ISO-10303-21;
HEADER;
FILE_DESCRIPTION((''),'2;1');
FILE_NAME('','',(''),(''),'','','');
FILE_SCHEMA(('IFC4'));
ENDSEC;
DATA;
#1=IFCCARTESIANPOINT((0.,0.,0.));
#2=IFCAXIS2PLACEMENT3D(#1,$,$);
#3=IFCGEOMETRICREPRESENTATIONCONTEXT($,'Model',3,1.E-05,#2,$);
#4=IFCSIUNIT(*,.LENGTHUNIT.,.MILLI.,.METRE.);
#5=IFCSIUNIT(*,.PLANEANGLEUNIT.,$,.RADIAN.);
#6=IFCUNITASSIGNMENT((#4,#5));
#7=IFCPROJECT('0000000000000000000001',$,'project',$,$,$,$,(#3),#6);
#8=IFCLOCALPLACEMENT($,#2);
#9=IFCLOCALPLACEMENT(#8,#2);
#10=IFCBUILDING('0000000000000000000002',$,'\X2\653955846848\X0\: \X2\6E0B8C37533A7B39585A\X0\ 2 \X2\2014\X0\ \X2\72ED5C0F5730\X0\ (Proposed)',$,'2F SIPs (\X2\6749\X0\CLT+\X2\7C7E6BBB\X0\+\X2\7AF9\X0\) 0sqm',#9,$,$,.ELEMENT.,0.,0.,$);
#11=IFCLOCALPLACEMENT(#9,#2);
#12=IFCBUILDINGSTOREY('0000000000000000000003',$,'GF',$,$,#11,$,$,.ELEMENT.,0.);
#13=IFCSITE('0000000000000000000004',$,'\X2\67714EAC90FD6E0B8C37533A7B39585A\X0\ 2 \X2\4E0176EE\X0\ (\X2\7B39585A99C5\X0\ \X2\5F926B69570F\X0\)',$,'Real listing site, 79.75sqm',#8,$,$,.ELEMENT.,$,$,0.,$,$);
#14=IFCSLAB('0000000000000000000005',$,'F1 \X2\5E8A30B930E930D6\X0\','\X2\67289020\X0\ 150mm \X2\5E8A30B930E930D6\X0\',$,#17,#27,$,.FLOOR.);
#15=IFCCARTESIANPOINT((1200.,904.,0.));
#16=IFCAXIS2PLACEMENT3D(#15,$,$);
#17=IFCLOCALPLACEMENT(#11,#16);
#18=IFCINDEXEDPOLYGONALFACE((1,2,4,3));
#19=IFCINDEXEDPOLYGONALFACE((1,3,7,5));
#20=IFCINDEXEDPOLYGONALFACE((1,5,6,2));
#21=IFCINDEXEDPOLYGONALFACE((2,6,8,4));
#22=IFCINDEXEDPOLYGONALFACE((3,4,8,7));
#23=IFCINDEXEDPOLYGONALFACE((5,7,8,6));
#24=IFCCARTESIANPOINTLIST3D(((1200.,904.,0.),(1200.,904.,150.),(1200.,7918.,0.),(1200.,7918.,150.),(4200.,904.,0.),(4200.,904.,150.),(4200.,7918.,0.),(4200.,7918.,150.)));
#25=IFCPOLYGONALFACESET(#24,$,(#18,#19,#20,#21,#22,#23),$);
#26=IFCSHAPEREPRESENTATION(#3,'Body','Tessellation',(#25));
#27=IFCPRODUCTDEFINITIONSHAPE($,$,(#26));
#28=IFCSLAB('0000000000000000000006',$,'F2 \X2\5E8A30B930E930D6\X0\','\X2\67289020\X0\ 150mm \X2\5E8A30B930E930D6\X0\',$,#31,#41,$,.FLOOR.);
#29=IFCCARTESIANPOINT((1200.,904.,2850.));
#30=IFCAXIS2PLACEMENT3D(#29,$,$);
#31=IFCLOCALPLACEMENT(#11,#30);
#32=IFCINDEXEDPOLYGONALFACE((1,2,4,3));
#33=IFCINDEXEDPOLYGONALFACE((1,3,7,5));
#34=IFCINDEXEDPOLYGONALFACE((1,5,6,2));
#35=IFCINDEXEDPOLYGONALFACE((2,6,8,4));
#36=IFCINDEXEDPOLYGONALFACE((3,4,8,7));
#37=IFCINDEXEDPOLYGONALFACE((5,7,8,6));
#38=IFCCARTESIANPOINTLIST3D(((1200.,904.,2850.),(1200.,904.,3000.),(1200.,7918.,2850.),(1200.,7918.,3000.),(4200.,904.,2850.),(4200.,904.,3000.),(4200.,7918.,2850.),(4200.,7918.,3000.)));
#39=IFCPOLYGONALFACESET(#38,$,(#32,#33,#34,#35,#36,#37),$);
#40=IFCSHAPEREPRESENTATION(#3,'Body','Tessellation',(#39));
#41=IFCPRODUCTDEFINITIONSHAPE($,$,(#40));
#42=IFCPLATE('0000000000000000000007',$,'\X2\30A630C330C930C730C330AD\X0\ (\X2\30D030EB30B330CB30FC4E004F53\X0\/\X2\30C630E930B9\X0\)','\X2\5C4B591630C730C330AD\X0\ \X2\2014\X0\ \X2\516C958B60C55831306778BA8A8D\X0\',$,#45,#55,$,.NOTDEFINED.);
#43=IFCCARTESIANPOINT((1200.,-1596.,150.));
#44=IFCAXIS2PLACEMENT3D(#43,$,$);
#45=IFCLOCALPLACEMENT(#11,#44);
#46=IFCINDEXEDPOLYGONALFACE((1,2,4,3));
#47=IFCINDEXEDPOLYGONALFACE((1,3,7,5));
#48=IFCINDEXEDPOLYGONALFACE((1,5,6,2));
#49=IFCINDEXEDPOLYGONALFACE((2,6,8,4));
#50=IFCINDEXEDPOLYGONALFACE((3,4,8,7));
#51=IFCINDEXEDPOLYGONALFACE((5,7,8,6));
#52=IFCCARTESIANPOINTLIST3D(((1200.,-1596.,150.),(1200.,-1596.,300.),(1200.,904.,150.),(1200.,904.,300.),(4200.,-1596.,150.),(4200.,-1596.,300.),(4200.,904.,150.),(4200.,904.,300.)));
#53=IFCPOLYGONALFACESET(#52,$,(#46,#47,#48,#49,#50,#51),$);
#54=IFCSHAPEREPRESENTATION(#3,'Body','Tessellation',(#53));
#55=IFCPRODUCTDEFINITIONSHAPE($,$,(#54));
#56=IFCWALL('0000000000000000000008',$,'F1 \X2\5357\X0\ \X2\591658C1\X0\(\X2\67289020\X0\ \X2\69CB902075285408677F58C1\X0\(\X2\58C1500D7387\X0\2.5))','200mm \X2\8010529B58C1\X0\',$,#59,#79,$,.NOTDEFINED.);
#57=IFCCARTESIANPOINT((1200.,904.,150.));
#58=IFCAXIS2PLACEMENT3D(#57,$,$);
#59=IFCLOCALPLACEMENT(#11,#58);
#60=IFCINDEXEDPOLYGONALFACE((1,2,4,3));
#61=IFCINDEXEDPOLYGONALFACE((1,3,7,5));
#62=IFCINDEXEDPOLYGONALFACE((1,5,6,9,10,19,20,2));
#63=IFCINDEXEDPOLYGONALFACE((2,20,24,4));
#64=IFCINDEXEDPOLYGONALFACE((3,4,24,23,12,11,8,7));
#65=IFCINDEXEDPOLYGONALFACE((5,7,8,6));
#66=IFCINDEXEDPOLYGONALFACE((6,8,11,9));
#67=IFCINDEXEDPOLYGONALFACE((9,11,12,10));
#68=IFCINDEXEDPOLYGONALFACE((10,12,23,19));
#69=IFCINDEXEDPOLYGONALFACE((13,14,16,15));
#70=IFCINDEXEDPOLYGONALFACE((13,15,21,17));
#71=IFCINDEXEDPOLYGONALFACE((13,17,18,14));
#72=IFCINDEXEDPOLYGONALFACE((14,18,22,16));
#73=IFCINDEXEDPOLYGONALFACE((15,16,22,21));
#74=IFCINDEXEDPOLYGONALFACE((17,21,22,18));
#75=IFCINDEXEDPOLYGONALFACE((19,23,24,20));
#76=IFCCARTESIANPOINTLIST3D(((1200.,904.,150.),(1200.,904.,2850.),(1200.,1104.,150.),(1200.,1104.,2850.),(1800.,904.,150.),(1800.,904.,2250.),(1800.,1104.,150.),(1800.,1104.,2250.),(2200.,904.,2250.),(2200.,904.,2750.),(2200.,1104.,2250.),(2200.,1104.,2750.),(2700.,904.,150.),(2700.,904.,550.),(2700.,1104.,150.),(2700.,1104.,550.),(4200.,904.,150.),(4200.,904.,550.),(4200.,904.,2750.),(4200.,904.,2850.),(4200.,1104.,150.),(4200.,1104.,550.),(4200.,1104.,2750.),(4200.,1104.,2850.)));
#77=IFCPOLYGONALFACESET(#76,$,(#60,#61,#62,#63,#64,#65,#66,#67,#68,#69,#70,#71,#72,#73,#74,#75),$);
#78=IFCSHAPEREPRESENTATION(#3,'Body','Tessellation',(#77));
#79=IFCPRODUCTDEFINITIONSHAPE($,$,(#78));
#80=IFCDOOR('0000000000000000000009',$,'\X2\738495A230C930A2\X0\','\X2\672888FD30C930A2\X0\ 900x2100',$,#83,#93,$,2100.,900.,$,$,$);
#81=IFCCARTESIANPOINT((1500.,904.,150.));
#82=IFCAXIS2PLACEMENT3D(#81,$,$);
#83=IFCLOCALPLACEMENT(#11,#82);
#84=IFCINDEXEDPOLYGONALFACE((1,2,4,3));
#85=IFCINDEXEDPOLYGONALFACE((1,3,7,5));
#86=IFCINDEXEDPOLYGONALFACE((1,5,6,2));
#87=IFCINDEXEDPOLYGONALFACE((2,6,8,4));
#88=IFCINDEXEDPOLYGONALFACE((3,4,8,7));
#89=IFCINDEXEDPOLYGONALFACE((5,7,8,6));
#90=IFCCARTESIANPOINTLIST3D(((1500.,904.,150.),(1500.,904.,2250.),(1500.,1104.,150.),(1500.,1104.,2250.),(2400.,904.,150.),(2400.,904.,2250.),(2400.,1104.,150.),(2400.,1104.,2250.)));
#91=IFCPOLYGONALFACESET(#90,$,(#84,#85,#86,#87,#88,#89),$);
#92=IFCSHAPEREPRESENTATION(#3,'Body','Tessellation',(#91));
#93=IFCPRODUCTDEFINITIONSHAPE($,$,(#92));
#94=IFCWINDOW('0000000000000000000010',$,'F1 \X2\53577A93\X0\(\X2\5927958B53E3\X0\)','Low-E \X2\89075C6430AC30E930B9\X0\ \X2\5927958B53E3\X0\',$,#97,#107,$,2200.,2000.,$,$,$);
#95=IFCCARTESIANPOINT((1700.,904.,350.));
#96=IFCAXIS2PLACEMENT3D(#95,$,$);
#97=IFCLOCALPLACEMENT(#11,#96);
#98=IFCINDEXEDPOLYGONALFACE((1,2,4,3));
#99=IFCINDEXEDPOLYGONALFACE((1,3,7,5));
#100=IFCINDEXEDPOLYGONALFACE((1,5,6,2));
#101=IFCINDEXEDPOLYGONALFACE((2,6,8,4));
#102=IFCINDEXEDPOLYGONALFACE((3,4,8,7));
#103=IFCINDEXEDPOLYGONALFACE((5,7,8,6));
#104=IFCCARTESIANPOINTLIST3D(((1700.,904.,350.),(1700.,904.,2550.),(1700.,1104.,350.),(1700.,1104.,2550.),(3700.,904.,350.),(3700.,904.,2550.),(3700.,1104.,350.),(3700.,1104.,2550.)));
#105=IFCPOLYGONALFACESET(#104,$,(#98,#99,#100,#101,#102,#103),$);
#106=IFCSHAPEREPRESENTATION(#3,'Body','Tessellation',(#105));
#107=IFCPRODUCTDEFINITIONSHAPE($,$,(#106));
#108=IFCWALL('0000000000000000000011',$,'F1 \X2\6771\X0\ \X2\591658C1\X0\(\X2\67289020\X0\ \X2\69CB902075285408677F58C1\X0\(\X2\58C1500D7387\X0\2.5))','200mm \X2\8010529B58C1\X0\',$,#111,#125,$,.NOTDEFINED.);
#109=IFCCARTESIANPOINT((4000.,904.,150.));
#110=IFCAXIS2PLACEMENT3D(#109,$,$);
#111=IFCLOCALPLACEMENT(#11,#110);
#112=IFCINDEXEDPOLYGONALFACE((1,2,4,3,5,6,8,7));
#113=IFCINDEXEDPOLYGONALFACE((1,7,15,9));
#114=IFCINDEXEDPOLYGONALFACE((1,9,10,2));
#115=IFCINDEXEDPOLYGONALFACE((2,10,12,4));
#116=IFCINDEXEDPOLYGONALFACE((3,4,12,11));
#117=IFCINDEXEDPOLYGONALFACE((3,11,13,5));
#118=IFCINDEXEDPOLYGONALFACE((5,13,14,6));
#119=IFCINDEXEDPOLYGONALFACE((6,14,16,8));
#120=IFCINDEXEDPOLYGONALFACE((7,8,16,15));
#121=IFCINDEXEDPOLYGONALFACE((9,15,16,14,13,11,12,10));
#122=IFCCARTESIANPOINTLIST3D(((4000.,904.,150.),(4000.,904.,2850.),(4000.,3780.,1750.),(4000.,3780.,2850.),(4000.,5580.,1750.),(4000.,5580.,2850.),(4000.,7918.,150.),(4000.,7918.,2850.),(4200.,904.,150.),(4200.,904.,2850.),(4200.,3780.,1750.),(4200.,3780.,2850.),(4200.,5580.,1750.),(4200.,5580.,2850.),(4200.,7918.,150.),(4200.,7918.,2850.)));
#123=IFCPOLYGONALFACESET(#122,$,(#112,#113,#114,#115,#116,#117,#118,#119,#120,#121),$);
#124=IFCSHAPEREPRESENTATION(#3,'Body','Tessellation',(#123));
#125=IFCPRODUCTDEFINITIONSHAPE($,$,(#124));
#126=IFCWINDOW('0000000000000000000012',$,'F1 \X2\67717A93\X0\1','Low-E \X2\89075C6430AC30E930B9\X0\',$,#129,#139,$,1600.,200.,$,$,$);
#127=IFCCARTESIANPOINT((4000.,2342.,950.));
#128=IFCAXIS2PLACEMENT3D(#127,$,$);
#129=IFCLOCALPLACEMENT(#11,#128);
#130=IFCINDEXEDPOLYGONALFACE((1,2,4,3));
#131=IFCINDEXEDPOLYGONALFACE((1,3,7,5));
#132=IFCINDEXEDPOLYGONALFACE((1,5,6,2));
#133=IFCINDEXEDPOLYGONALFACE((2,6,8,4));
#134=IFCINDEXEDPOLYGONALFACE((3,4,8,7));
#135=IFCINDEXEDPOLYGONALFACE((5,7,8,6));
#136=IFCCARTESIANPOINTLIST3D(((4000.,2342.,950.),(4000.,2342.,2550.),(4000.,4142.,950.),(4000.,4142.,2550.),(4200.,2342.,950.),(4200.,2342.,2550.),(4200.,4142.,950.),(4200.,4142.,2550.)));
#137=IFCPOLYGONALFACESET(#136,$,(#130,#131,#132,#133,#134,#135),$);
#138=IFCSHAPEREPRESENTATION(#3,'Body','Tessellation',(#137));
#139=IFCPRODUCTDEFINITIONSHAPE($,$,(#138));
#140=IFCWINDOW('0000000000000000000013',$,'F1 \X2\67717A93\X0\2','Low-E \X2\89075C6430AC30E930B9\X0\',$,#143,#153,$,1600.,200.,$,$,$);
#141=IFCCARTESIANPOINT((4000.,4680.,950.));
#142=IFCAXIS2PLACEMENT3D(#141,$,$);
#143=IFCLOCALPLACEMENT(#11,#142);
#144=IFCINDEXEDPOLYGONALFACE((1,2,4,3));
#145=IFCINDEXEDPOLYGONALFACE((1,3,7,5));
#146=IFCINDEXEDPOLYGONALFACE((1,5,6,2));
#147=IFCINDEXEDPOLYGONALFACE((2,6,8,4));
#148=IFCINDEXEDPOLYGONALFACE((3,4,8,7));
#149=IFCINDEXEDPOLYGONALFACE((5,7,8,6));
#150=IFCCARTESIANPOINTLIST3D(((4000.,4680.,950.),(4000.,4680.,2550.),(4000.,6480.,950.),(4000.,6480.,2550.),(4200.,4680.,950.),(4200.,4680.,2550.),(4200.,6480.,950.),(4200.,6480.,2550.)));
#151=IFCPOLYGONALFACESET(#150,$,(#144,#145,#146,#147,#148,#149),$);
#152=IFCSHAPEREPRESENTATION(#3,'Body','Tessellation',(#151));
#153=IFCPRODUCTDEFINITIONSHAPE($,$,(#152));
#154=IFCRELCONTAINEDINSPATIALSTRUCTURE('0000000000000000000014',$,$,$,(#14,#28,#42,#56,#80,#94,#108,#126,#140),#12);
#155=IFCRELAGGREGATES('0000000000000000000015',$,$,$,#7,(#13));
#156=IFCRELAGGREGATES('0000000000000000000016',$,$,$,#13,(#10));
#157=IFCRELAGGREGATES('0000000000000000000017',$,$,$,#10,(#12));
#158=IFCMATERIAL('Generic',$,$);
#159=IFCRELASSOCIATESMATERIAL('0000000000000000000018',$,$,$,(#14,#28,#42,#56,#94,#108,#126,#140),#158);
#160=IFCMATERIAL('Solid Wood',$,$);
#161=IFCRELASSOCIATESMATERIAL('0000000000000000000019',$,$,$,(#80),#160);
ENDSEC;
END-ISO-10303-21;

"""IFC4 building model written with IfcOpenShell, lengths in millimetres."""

from ifc_helpers import new_model, si_unit, frame, frame_2d, origin, place, context, project, spatial, rectangle, extrude, material, element, fill, save


model = new_model("IFC4")

# Units and contexts
model_context = context("Model", 3, precision=1e-05, world=origin())
ifc_project = project(units=[si_unit("LENGTHUNIT", "METRE", prefix="MILLI"), si_unit("PLANEANGLEUNIT", "RADIAN")], contexts=[model_context])

# Site, building, storey
site_placement = place(None, origin())
site = spatial("IfcSite", under=ifc_project, at=site_placement, Name="東京都渋谷区笹塚 2 丁目 (笹塚駅 徒歩圏)", ObjectType="Real listing site, 79.75sqm", CompositionType="ELEMENT", RefElevation=0.0)
building_placement = place(site_placement, origin())
building = spatial("IfcBuilding", under=site, at=building_placement, Name="改善案: 渋谷区笹塚 2 — 狭小地 (Proposed)", ObjectType="2F SIPs (杉CLT+籾殻+竹) 0sqm", CompositionType="ELEMENT", ElevationOfRefHeight=0.0, ElevationOfTerrain=0.0)
storey_placement = place(building_placement, origin())
storey = spatial("IfcBuildingStorey", under=building, at=storey_placement, Name="GF", CompositionType="ELEMENT", Elevation=0.0)

# Slabs
ifc_material_1 = material(Name="Generic")
slab_1_placement = place(storey_placement, frame((1200.0, 904.0, 0.0)))
element("IfcSlab", 1, at=slab_1_placement, inside=storey, material=ifc_material_1, Name="F1 床スラブ", Description="木造 150mm 床スラブ", PredefinedType="FLOOR", context=model_context, shape_type="SweptSolid", body=[
    extrude(rectangle(XDim=3000.0, YDim=7014.0, at=frame_2d((1500.0, 3507.0))), frame((1200.0, 904.0, 0.0)), (0.0, 0.0, 1.0), 150.0),
])
slab_2_placement = place(storey_placement, frame((1200.0, 904.0, 2850.0)))
element("IfcSlab", 2, at=slab_2_placement, inside=storey, material=ifc_material_1, Name="F2 床スラブ", Description="木造 150mm 床スラブ", PredefinedType="FLOOR", context=model_context, shape_type="SweptSolid", body=[
    extrude(rectangle(XDim=3000.0, YDim=7014.0, at=frame_2d((1500.0, 3507.0))), frame((1200.0, 904.0, 2850.0)), (0.0, 0.0, 1.0), 150.0),
])

# Plate
plate_placement = place(storey_placement, frame((1200.0, -1596.0, 150.0)))
element("IfcPlate", 3, at=plate_placement, inside=storey, material=ifc_material_1, Name="ウッドデッキ (バルコニー一体/テラス)", Description="屋外デッキ — 公開情報で確認", PredefinedType="NOTDEFINED", context=model_context, shape_type="SweptSolid", body=[
    extrude(rectangle(XDim=3000.0, YDim=2500.0, at=frame_2d((1500.0, 1250.0))), frame((1200.0, -1596.0, 150.0)), (0.0, 0.0, 1.0), 150.0),
])

# Wall, openings, door, window
wall_1_placement = place(storey_placement, frame((1200.0, 904.0, 150.0)))
wall_1 = element("IfcWall", 4, at=wall_1_placement, inside=storey, material=ifc_material_1, Name="F1 南 外壁(木造 構造用合板壁(壁倍率2.5))", Description="200mm 耐力壁", PredefinedType="NOTDEFINED", context=model_context, shape_type="SweptSolid", body=[
    extrude(rectangle(XDim=3000.0, YDim=200.0, at=frame_2d((1500.0, 100.0))), frame((1200.0, 904.0, 150.0)), (0.0, 0.0, 1.0), 2700.0),
])
opening_1_placement = place(storey_placement, frame((1500.0, 904.0, 150.0)))
opening_1 = element("IfcOpeningElement", 5, at=opening_1_placement, cuts=wall_1, PredefinedType="NOTDEFINED", context=model_context, shape_type="SweptSolid", body=[
    extrude(rectangle(XDim=900.0, YDim=200.0, at=frame_2d((450.0, 100.0))), frame((1500.0, 904.0, 150.0)), (0.0, 0.0, 1.0), 2100.0),
])
opening_2_placement = place(storey_placement, frame((1700.0, 904.0, 350.0)))
opening_2 = element("IfcOpeningElement", 6, at=opening_2_placement, cuts=wall_1, PredefinedType="NOTDEFINED", context=model_context, shape_type="SweptSolid", body=[
    extrude(rectangle(XDim=2000.0, YDim=200.0, at=frame_2d((1000.0, 100.0))), frame((1700.0, 904.0, 350.0)), (0.0, 0.0, 1.0), 2200.0),
])
ifc_material_2 = material(Name="Solid Wood")
door_placement = place(storey_placement, frame((1500.0, 904.0, 150.0)))
door = element("IfcDoor", 7, at=door_placement, inside=storey, material=ifc_material_2, Name="玄関ドア", Description="木製ドア 900x2100", OverallHeight=2100.0, OverallWidth=900.0, context=model_context, shape_type="SweptSolid", body=[
    extrude(rectangle(XDim=900.0, YDim=200.0, at=frame_2d((450.0, 100.0))), frame((1500.0, 904.0, 150.0)), (0.0, 0.0, 1.0), 2100.0),
])
fill(opening_1, door)
window_1_placement = place(storey_placement, frame((1700.0, 904.0, 350.0)))
window_1 = element("IfcWindow", 8, at=window_1_placement, inside=storey, material=ifc_material_1, Name="F1 南窓(大開口)", Description="Low-E 複層ガラス 大開口", OverallHeight=2200.0, OverallWidth=2000.0, context=model_context, shape_type="SweptSolid", body=[
    extrude(rectangle(XDim=2000.0, YDim=200.0, at=frame_2d((1000.0, 100.0))), frame((1700.0, 904.0, 350.0)), (0.0, 0.0, 1.0), 2200.0),
])
fill(opening_2, window_1)

# Wall, openings, windows
wall_2_placement = place(storey_placement, frame((4000.0, 904.0, 150.0)))
wall_2 = element("IfcWall", 9, at=wall_2_placement, inside=storey, material=ifc_material_1, Name="F1 東 外壁(木造 構造用合板壁(壁倍率2.5))", Description="200mm 耐力壁", PredefinedType="NOTDEFINED", context=model_context, shape_type="SweptSolid", body=[
    extrude(rectangle(XDim=200.0, YDim=7014.0, at=frame_2d((100.0, 3507.0))), frame((4000.0, 904.0, 150.0)), (0.0, 0.0, 1.0), 2700.0),
])
opening_3_placement = place(storey_placement, frame((4000.0, 2342.0, 950.0)))
opening_3 = element("IfcOpeningElement", 10, at=opening_3_placement, cuts=wall_2, PredefinedType="NOTDEFINED", context=model_context, shape_type="SweptSolid", body=[
    extrude(rectangle(XDim=200.0, YDim=1800.0, at=frame_2d((100.0, 900.0))), frame((4000.0, 2342.0, 950.0)), (0.0, 0.0, 1.0), 1600.0),
])
opening_4_placement = place(storey_placement, frame((4000.0, 4680.0, 950.0)))
opening_4 = element("IfcOpeningElement", 11, at=opening_4_placement, cuts=wall_2, PredefinedType="NOTDEFINED", context=model_context, shape_type="SweptSolid", body=[
    extrude(rectangle(XDim=200.0, YDim=1800.0, at=frame_2d((100.0, 900.0))), frame((4000.0, 4680.0, 950.0)), (0.0, 0.0, 1.0), 1600.0),
])
window_2_placement = place(storey_placement, frame((4000.0, 2342.0, 950.0)))
window_2 = element("IfcWindow", 12, at=window_2_placement, inside=storey, material=ifc_material_1, Name="F1 東窓1", Description="Low-E 複層ガラス", OverallHeight=1600.0, OverallWidth=200.0, context=model_context, shape_type="SweptSolid", body=[
    extrude(rectangle(XDim=200.0, YDim=1800.0, at=frame_2d((100.0, 900.0))), frame((4000.0, 2342.0, 950.0)), (0.0, 0.0, 1.0), 1600.0),
])
fill(opening_3, window_2)
window_3_placement = place(storey_placement, frame((4000.0, 4680.0, 950.0)))
window_3 = element("IfcWindow", 13, at=window_3_placement, inside=storey, material=ifc_material_1, Name="F1 東窓2", Description="Low-E 複層ガラス", OverallHeight=1600.0, OverallWidth=200.0, context=model_context, shape_type="SweptSolid", body=[
    extrude(rectangle(XDim=200.0, YDim=1800.0, at=frame_2d((100.0, 900.0))), frame((4000.0, 4680.0, 950.0)), (0.0, 0.0, 1.0), 1600.0),
])
fill(opening_4, window_3)

save(model, "model.ifc")
